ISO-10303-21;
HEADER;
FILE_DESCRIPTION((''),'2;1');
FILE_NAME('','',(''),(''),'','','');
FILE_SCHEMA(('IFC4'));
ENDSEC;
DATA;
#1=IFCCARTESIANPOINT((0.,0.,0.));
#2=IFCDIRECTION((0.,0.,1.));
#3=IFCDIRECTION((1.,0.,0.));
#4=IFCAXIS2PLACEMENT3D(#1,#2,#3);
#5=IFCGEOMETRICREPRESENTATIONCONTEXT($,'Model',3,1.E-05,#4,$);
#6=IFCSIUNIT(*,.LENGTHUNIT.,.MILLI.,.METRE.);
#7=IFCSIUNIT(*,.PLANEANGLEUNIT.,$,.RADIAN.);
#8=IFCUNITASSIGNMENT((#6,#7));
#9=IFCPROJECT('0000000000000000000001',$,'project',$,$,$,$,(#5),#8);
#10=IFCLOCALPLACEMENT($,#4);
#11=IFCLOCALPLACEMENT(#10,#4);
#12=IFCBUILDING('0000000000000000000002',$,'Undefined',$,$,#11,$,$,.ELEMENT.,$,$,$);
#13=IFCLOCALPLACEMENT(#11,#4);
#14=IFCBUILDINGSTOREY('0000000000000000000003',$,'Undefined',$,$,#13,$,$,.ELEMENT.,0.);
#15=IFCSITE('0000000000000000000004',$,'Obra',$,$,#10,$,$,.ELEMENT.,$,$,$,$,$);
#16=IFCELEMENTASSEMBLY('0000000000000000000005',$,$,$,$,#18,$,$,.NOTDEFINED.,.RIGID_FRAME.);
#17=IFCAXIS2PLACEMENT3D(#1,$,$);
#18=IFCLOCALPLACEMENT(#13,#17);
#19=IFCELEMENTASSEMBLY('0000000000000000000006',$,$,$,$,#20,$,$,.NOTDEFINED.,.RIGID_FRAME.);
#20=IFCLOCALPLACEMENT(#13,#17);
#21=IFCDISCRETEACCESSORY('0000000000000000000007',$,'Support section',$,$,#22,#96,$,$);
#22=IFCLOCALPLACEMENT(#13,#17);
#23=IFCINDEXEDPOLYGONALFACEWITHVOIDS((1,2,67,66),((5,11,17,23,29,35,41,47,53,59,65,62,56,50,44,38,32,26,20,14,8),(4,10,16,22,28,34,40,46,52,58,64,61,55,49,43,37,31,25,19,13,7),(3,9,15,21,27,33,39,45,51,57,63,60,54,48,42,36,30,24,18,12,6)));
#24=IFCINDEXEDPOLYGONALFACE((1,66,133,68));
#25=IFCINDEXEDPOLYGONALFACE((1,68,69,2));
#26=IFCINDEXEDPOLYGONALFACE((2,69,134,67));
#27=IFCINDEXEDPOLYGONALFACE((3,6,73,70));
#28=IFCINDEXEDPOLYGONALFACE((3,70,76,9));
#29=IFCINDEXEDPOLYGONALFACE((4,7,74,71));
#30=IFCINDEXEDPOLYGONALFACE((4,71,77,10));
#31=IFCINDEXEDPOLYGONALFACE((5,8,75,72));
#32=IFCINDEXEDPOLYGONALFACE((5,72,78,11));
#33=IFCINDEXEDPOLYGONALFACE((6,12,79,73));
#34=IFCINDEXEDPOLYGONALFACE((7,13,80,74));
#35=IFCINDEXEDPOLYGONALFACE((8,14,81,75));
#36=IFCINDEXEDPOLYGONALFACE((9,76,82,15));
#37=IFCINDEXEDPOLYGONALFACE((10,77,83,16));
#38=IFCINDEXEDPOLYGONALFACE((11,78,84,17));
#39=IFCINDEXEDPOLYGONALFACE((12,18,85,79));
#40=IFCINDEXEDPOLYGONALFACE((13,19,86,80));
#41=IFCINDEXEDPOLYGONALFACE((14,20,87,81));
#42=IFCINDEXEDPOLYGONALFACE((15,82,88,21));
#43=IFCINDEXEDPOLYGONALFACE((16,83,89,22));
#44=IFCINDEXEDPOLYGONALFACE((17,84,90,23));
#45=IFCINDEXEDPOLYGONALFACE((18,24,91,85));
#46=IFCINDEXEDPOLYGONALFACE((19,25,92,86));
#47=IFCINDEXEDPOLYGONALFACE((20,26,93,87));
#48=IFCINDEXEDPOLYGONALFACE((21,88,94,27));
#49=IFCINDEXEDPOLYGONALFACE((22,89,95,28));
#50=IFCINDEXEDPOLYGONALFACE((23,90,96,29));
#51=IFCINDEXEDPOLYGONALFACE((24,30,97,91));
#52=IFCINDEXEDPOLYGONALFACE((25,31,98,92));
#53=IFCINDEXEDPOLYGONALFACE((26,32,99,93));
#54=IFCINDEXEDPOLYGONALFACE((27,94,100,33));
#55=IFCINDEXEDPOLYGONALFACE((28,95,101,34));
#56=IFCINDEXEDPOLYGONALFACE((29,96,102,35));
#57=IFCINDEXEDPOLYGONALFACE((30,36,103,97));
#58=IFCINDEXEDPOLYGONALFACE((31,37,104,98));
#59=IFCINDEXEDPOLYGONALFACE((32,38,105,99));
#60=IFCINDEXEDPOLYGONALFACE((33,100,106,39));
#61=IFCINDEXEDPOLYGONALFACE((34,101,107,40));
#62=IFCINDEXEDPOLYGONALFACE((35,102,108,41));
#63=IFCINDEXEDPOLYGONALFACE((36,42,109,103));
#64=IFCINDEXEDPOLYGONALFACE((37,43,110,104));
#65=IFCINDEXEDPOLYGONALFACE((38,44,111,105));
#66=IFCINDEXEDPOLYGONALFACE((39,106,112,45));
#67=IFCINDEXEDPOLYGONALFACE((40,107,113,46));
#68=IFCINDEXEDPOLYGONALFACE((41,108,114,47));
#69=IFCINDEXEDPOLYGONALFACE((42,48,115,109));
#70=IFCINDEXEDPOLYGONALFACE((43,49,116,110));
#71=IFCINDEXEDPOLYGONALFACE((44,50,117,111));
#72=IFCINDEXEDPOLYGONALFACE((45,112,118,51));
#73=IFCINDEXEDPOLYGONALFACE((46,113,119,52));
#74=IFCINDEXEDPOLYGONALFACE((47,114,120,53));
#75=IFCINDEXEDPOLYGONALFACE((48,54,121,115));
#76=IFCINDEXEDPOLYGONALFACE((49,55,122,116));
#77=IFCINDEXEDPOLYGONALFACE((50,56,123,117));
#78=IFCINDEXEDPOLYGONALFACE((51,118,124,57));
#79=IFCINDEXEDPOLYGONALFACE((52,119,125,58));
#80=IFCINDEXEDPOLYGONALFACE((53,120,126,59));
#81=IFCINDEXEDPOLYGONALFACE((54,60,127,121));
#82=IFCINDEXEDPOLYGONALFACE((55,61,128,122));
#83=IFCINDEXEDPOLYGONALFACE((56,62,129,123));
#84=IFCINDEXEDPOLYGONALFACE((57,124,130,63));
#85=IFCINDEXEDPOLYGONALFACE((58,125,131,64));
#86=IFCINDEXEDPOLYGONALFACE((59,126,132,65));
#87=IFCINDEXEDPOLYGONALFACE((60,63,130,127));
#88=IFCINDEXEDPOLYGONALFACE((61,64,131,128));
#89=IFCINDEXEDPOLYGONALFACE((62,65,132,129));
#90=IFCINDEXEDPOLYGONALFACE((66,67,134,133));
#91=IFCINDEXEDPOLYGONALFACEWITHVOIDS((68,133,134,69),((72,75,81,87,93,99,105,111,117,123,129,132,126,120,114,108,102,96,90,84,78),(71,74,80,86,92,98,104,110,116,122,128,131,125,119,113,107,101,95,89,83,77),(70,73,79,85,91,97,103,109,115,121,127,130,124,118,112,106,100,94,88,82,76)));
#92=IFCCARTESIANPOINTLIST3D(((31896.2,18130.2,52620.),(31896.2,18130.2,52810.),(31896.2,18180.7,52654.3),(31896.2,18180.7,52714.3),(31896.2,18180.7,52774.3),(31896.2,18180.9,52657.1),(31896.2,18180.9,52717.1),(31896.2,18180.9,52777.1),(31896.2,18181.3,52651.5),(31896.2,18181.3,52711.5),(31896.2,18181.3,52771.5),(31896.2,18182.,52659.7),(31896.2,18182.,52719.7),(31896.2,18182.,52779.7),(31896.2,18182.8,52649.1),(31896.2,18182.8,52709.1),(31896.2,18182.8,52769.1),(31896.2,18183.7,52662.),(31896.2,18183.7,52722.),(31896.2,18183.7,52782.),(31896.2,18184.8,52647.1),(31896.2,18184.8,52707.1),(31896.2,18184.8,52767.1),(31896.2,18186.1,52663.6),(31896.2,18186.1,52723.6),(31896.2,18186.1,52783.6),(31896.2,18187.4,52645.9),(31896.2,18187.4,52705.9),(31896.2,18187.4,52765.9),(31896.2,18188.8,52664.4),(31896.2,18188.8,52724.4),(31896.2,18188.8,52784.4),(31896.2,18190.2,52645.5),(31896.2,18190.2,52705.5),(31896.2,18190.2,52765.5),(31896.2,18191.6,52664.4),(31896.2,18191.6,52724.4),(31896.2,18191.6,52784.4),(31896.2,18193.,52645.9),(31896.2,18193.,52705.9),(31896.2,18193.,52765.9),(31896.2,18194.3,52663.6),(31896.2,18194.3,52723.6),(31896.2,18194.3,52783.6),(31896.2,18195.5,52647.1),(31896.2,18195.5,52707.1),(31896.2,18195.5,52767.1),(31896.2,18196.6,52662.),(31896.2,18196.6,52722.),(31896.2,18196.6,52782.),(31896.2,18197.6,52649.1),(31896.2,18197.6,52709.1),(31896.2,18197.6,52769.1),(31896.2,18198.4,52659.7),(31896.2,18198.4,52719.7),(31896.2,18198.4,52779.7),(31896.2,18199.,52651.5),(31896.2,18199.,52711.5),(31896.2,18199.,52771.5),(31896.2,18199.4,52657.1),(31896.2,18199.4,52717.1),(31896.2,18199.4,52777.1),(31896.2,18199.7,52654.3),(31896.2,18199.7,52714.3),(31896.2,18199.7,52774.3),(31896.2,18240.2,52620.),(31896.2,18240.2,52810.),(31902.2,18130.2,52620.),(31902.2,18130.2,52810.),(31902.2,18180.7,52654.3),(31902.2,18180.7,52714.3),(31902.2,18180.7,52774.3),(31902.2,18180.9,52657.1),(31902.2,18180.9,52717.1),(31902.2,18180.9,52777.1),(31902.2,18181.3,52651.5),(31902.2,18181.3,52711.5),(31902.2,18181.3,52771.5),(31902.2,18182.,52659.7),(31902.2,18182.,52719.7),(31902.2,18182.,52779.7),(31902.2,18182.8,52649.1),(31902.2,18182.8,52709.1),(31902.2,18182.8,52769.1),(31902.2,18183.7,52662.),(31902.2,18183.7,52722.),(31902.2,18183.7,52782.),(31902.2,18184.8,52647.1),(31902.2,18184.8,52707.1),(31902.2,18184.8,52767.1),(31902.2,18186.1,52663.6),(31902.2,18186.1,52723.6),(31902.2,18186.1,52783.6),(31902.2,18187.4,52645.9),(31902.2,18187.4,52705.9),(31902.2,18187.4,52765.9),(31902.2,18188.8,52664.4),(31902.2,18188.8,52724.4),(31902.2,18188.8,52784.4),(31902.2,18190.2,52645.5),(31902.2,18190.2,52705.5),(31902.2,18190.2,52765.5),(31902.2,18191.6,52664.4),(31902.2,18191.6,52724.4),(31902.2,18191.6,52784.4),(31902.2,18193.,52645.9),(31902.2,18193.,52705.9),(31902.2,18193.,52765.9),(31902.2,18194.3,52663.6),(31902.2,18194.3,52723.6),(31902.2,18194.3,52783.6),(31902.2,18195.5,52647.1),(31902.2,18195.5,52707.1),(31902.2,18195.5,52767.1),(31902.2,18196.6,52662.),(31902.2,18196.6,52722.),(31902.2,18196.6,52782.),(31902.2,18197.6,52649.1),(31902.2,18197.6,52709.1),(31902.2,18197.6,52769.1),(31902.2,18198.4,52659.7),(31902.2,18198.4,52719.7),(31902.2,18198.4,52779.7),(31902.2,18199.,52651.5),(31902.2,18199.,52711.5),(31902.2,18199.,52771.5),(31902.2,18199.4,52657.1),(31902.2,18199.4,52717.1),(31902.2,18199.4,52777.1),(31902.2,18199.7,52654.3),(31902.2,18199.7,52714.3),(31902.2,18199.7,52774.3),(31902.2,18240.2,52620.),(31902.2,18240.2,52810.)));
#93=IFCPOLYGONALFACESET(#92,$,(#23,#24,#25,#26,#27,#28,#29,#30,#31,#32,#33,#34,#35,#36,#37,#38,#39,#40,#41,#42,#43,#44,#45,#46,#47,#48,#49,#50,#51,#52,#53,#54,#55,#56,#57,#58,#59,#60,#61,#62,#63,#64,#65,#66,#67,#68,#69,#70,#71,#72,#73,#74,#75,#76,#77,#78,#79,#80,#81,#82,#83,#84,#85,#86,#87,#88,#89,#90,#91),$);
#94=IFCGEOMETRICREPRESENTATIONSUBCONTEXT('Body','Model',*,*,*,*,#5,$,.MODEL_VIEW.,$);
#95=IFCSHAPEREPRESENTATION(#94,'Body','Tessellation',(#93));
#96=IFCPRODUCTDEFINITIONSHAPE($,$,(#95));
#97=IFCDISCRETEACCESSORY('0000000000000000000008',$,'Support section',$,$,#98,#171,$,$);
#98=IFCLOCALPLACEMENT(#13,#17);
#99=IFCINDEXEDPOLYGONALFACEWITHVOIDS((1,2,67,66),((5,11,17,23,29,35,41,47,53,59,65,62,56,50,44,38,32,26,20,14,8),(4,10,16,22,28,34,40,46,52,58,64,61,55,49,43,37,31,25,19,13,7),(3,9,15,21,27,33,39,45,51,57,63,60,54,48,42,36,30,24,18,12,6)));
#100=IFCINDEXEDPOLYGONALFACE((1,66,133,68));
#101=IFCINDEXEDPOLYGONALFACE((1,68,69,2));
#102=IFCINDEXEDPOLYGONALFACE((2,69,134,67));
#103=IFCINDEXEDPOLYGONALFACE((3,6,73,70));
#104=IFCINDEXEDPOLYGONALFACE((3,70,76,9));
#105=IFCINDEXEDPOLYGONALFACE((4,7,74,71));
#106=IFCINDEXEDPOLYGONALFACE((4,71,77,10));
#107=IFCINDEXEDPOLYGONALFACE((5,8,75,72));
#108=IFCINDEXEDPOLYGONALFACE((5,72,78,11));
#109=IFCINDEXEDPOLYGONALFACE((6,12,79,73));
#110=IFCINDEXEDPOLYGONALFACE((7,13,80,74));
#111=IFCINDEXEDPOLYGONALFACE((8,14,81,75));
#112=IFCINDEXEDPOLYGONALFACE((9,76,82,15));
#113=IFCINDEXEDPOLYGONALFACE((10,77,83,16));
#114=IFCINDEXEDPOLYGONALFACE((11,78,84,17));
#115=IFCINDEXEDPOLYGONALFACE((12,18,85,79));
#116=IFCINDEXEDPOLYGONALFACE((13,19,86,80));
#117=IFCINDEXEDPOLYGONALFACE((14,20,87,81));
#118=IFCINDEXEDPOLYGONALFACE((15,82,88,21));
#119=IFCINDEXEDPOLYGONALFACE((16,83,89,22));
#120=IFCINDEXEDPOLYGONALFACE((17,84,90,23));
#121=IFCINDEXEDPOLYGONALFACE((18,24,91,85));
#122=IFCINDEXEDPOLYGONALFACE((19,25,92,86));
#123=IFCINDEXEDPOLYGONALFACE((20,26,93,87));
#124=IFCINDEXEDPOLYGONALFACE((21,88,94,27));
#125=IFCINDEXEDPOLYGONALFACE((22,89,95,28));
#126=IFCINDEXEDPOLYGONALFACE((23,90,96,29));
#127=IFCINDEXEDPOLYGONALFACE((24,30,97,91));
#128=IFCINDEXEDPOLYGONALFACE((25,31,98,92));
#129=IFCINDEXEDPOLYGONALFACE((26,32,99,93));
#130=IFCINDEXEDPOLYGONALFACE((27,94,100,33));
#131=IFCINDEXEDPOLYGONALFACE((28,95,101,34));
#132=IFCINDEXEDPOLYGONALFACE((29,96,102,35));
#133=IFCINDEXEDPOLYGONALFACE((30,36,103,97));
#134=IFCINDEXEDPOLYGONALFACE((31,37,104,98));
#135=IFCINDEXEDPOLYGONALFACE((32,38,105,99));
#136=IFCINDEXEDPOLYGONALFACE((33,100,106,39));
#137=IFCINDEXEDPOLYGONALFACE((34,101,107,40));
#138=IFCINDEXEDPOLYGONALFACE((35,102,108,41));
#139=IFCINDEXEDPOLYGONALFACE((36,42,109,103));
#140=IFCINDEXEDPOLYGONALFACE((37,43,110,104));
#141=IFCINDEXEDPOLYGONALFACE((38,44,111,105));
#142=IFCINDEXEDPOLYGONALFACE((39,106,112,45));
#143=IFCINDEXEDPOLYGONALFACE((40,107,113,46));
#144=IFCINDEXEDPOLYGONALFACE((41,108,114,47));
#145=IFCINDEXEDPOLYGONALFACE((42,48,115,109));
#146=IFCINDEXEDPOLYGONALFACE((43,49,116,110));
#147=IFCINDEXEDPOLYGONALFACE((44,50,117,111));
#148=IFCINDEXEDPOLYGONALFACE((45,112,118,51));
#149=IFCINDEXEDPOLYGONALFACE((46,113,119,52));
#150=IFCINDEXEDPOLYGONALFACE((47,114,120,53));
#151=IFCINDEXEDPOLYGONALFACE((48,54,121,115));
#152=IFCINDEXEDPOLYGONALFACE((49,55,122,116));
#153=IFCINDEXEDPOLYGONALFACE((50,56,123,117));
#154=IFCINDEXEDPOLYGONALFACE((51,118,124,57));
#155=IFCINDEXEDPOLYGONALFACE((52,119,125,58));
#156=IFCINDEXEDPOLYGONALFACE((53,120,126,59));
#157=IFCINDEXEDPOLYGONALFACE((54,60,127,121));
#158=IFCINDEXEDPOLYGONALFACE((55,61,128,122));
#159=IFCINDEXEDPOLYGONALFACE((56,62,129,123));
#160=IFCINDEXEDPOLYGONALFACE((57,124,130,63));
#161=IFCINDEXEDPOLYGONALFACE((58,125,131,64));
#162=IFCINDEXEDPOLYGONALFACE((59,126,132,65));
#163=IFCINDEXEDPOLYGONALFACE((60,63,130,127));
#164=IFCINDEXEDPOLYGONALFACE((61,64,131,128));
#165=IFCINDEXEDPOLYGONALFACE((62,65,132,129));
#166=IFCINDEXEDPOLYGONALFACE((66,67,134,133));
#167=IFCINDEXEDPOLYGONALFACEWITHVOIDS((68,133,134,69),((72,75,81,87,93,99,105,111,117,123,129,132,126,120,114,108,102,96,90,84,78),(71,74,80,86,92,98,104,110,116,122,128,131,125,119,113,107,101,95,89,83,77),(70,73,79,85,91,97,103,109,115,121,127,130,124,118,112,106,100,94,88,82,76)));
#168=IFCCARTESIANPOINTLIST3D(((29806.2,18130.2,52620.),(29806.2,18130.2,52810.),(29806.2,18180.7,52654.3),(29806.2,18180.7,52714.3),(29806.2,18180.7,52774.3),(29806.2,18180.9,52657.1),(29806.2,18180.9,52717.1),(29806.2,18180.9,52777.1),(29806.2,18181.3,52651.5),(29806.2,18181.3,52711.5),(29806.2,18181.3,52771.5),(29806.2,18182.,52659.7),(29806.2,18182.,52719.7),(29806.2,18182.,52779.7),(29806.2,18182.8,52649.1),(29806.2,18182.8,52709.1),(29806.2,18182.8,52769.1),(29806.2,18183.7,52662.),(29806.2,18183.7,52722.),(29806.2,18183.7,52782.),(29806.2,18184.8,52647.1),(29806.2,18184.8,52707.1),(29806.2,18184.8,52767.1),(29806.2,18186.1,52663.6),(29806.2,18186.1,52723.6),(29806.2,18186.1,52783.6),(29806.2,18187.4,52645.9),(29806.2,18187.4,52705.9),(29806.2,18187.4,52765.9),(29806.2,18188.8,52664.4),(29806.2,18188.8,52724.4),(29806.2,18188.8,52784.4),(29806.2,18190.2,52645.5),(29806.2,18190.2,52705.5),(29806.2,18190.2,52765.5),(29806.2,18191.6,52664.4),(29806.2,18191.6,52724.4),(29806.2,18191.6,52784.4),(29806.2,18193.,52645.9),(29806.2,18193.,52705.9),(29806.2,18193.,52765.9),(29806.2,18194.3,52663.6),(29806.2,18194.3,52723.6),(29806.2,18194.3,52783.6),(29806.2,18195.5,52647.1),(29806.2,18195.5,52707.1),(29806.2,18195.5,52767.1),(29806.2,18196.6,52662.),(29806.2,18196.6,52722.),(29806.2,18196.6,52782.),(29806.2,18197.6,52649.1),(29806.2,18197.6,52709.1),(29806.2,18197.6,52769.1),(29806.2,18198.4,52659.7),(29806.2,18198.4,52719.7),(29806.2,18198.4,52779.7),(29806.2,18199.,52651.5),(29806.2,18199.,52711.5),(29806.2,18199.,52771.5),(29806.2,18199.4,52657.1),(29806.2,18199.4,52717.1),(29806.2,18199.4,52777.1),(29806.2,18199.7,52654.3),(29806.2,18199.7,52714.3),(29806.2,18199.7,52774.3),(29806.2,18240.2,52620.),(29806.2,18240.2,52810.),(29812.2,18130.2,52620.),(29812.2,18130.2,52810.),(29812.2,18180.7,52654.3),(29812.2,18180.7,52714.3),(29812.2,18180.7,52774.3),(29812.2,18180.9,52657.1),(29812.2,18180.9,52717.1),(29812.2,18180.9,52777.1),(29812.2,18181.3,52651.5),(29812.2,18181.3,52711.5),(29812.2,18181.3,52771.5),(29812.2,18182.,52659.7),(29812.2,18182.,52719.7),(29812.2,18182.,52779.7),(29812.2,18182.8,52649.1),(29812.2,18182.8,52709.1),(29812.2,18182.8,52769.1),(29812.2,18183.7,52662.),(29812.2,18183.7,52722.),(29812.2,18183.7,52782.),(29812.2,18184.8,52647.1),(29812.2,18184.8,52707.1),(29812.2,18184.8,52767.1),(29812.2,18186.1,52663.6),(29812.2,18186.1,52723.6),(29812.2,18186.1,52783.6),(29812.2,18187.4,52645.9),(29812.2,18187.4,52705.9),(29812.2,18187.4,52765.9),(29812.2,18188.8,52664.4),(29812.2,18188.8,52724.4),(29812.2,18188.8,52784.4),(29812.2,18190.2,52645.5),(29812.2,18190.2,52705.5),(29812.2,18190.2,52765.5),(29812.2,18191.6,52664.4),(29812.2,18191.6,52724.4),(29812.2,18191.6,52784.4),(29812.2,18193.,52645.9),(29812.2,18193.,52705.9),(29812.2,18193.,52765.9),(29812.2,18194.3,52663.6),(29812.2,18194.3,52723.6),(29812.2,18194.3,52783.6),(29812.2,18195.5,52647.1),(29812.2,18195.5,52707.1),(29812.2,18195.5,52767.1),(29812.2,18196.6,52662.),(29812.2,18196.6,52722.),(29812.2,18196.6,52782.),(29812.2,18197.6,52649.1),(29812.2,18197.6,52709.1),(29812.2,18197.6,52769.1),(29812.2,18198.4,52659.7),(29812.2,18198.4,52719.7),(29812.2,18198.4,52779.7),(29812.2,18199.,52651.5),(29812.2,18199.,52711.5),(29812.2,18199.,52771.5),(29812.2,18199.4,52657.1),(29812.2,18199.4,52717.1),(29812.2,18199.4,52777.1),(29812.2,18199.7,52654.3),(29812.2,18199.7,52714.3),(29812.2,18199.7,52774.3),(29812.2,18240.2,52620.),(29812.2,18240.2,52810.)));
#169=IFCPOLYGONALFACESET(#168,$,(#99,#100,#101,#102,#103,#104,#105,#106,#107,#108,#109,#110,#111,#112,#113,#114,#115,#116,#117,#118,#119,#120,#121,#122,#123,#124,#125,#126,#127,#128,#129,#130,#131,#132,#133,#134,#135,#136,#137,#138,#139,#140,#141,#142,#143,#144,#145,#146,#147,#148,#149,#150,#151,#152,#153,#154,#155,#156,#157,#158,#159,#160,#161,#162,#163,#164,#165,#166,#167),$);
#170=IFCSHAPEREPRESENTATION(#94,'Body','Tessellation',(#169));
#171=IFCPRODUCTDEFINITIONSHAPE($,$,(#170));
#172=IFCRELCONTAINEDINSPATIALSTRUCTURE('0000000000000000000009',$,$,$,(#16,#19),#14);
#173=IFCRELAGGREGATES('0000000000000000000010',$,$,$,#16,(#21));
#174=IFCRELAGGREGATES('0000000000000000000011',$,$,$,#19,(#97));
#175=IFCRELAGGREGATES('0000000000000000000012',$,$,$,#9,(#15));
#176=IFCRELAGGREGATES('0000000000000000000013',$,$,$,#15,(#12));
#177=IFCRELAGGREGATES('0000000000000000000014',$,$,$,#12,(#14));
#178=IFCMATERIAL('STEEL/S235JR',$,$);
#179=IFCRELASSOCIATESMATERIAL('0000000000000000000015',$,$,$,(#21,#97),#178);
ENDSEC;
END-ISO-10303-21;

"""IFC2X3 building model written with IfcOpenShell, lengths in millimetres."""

from ifc_helpers import new_model, si_unit, frame, origin_with_axes, origin_2d_with_axis, place, context, subcontext, project, spatial, rectangle, circle, extrude, source, transform, mapped, material, element, aggregate, save


model = new_model("IFC2X3")

# Units and contexts
model_context = context("Model", 3, precision=1e-05, world=origin_with_axes())
body_context = subcontext(model_context, "Body", "Model", "MODEL_VIEW")
ifc_project = project(units=[si_unit("LENGTHUNIT", "METRE", prefix="MILLI"), si_unit("PLANEANGLEUNIT", "RADIAN")], contexts=[model_context])

# Site, building, storey
site_placement = place(None, origin_with_axes())
site = spatial("IfcSite", under=ifc_project, at=site_placement, Name="Obra", CompositionType="ELEMENT")
building_placement = place(site_placement, origin_with_axes())
building = spatial("IfcBuilding", under=site, at=building_placement, Name="Undefined", CompositionType="ELEMENT")
storey_placement = place(building_placement, origin_with_axes())
storey = spatial("IfcBuildingStorey", under=building, at=storey_placement, Name="Undefined", CompositionType="ELEMENT", Elevation=0.0)

# Element assemblies
assembly_1_placement = place(storey_placement, origin_with_axes())
assembly_1 = element("IfcElementAssembly", 1, at=assembly_1_placement, inside=storey, AssemblyPlace="NOTDEFINED", PredefinedType="RIGID_FRAME")
ifc_material_1 = material(Name="STEEL/S235JR")
assembly_2_placement = place(storey_placement, origin_with_axes())
assembly_2 = element("IfcElementAssembly", 2, at=assembly_2_placement, inside=storey, AssemblyPlace="NOTDEFINED", PredefinedType="RIGID_FRAME")

# Discrete accessories, openings
discrete_accessory_1_placement = place(assembly_1_placement, frame((31899.2, 18185.2, 52620.0), z_axis=(0.0, 0.0, 1.0), x_axis=(0.000002, -1.0, 0.0)))
discrete_accessory_1 = element("IfcDiscreteAccessory", 3, at=discrete_accessory_1_placement, material=ifc_material_1, Name="Support section", context=body_context, shape_type="SweptSolid", body=[
    extrude(rectangle(XDim=6.0, YDim=110.0, at=origin_2d_with_axis()), frame((0.0, 0.0, 190.0), z_axis=(0.0, 0.0, -1.0), x_axis=(0.0, 1.0, 0.0)), (0.0, 0.0, 1.0), 190.0),
])
shared_shape_1 = source(origin_with_axes(), body_context, "Body", "SweptSolid", [
    extrude(circle(Radius=9.5, at=origin_2d_with_axis()), frame((0.0, -9.2, 0.0), z_axis=(0.0, 1.0, 0.0), x_axis=(1.0, 0.0, 0.0)), (0.0, 0.0, 1.0), 6.2),
])
opening_1_placement = place(assembly_1_placement, frame((31893.1, 18140.2, 52835.0), z_axis=(-0.000002, 1.0, 0.0), x_axis=(0.0, 0.0, -1.0)))
element("IfcOpeningElement", 4, at=opening_1_placement, cuts=discrete_accessory_1, ObjectType="Opening", context=body_context, shape_type="MappedRepresentation", body=[
    mapped(shared_shape_1, transform((60.0, 0.0, 50.0))),
    mapped(shared_shape_1, transform((120.0, 0.0, 50.0))),
    mapped(shared_shape_1, transform((180.0, 0.0, 50.0))),
])
aggregate(assembly_1, [discrete_accessory_1])
discrete_accessory_2_placement = place(assembly_2_placement, frame((29809.2, 18185.2, 52620.0), z_axis=(0.0, 0.0, 1.0), x_axis=(0.000002, -1.0, 0.0)))
discrete_accessory_2 = element("IfcDiscreteAccessory", 5, at=discrete_accessory_2_placement, material=ifc_material_1, Name="Support section", context=body_context, shape_type="SweptSolid", body=[
    extrude(rectangle(XDim=6.0, YDim=110.0, at=origin_2d_with_axis()), frame((0.0, 0.0, 190.0), z_axis=(0.0, 0.0, -1.0), x_axis=(0.0, 1.0, 0.0)), (0.0, 0.0, 1.0), 190.0),
])
opening_2_placement = place(assembly_2_placement, frame((29803.1, 18140.2, 52835.0), z_axis=(-0.000002, 1.0, 0.0), x_axis=(0.0, 0.0, -1.0)))
element("IfcOpeningElement", 6, at=opening_2_placement, cuts=discrete_accessory_2, ObjectType="Opening", context=body_context, shape_type="MappedRepresentation", body=[
    mapped(shared_shape_1, transform((60.0, 0.0, 50.0))),
    mapped(shared_shape_1, transform((120.0, 0.0, 50.0))),
    mapped(shared_shape_1, transform((180.0, 0.0, 50.0))),
])
aggregate(assembly_2, [discrete_accessory_2])

save(model, "model.ifc")
